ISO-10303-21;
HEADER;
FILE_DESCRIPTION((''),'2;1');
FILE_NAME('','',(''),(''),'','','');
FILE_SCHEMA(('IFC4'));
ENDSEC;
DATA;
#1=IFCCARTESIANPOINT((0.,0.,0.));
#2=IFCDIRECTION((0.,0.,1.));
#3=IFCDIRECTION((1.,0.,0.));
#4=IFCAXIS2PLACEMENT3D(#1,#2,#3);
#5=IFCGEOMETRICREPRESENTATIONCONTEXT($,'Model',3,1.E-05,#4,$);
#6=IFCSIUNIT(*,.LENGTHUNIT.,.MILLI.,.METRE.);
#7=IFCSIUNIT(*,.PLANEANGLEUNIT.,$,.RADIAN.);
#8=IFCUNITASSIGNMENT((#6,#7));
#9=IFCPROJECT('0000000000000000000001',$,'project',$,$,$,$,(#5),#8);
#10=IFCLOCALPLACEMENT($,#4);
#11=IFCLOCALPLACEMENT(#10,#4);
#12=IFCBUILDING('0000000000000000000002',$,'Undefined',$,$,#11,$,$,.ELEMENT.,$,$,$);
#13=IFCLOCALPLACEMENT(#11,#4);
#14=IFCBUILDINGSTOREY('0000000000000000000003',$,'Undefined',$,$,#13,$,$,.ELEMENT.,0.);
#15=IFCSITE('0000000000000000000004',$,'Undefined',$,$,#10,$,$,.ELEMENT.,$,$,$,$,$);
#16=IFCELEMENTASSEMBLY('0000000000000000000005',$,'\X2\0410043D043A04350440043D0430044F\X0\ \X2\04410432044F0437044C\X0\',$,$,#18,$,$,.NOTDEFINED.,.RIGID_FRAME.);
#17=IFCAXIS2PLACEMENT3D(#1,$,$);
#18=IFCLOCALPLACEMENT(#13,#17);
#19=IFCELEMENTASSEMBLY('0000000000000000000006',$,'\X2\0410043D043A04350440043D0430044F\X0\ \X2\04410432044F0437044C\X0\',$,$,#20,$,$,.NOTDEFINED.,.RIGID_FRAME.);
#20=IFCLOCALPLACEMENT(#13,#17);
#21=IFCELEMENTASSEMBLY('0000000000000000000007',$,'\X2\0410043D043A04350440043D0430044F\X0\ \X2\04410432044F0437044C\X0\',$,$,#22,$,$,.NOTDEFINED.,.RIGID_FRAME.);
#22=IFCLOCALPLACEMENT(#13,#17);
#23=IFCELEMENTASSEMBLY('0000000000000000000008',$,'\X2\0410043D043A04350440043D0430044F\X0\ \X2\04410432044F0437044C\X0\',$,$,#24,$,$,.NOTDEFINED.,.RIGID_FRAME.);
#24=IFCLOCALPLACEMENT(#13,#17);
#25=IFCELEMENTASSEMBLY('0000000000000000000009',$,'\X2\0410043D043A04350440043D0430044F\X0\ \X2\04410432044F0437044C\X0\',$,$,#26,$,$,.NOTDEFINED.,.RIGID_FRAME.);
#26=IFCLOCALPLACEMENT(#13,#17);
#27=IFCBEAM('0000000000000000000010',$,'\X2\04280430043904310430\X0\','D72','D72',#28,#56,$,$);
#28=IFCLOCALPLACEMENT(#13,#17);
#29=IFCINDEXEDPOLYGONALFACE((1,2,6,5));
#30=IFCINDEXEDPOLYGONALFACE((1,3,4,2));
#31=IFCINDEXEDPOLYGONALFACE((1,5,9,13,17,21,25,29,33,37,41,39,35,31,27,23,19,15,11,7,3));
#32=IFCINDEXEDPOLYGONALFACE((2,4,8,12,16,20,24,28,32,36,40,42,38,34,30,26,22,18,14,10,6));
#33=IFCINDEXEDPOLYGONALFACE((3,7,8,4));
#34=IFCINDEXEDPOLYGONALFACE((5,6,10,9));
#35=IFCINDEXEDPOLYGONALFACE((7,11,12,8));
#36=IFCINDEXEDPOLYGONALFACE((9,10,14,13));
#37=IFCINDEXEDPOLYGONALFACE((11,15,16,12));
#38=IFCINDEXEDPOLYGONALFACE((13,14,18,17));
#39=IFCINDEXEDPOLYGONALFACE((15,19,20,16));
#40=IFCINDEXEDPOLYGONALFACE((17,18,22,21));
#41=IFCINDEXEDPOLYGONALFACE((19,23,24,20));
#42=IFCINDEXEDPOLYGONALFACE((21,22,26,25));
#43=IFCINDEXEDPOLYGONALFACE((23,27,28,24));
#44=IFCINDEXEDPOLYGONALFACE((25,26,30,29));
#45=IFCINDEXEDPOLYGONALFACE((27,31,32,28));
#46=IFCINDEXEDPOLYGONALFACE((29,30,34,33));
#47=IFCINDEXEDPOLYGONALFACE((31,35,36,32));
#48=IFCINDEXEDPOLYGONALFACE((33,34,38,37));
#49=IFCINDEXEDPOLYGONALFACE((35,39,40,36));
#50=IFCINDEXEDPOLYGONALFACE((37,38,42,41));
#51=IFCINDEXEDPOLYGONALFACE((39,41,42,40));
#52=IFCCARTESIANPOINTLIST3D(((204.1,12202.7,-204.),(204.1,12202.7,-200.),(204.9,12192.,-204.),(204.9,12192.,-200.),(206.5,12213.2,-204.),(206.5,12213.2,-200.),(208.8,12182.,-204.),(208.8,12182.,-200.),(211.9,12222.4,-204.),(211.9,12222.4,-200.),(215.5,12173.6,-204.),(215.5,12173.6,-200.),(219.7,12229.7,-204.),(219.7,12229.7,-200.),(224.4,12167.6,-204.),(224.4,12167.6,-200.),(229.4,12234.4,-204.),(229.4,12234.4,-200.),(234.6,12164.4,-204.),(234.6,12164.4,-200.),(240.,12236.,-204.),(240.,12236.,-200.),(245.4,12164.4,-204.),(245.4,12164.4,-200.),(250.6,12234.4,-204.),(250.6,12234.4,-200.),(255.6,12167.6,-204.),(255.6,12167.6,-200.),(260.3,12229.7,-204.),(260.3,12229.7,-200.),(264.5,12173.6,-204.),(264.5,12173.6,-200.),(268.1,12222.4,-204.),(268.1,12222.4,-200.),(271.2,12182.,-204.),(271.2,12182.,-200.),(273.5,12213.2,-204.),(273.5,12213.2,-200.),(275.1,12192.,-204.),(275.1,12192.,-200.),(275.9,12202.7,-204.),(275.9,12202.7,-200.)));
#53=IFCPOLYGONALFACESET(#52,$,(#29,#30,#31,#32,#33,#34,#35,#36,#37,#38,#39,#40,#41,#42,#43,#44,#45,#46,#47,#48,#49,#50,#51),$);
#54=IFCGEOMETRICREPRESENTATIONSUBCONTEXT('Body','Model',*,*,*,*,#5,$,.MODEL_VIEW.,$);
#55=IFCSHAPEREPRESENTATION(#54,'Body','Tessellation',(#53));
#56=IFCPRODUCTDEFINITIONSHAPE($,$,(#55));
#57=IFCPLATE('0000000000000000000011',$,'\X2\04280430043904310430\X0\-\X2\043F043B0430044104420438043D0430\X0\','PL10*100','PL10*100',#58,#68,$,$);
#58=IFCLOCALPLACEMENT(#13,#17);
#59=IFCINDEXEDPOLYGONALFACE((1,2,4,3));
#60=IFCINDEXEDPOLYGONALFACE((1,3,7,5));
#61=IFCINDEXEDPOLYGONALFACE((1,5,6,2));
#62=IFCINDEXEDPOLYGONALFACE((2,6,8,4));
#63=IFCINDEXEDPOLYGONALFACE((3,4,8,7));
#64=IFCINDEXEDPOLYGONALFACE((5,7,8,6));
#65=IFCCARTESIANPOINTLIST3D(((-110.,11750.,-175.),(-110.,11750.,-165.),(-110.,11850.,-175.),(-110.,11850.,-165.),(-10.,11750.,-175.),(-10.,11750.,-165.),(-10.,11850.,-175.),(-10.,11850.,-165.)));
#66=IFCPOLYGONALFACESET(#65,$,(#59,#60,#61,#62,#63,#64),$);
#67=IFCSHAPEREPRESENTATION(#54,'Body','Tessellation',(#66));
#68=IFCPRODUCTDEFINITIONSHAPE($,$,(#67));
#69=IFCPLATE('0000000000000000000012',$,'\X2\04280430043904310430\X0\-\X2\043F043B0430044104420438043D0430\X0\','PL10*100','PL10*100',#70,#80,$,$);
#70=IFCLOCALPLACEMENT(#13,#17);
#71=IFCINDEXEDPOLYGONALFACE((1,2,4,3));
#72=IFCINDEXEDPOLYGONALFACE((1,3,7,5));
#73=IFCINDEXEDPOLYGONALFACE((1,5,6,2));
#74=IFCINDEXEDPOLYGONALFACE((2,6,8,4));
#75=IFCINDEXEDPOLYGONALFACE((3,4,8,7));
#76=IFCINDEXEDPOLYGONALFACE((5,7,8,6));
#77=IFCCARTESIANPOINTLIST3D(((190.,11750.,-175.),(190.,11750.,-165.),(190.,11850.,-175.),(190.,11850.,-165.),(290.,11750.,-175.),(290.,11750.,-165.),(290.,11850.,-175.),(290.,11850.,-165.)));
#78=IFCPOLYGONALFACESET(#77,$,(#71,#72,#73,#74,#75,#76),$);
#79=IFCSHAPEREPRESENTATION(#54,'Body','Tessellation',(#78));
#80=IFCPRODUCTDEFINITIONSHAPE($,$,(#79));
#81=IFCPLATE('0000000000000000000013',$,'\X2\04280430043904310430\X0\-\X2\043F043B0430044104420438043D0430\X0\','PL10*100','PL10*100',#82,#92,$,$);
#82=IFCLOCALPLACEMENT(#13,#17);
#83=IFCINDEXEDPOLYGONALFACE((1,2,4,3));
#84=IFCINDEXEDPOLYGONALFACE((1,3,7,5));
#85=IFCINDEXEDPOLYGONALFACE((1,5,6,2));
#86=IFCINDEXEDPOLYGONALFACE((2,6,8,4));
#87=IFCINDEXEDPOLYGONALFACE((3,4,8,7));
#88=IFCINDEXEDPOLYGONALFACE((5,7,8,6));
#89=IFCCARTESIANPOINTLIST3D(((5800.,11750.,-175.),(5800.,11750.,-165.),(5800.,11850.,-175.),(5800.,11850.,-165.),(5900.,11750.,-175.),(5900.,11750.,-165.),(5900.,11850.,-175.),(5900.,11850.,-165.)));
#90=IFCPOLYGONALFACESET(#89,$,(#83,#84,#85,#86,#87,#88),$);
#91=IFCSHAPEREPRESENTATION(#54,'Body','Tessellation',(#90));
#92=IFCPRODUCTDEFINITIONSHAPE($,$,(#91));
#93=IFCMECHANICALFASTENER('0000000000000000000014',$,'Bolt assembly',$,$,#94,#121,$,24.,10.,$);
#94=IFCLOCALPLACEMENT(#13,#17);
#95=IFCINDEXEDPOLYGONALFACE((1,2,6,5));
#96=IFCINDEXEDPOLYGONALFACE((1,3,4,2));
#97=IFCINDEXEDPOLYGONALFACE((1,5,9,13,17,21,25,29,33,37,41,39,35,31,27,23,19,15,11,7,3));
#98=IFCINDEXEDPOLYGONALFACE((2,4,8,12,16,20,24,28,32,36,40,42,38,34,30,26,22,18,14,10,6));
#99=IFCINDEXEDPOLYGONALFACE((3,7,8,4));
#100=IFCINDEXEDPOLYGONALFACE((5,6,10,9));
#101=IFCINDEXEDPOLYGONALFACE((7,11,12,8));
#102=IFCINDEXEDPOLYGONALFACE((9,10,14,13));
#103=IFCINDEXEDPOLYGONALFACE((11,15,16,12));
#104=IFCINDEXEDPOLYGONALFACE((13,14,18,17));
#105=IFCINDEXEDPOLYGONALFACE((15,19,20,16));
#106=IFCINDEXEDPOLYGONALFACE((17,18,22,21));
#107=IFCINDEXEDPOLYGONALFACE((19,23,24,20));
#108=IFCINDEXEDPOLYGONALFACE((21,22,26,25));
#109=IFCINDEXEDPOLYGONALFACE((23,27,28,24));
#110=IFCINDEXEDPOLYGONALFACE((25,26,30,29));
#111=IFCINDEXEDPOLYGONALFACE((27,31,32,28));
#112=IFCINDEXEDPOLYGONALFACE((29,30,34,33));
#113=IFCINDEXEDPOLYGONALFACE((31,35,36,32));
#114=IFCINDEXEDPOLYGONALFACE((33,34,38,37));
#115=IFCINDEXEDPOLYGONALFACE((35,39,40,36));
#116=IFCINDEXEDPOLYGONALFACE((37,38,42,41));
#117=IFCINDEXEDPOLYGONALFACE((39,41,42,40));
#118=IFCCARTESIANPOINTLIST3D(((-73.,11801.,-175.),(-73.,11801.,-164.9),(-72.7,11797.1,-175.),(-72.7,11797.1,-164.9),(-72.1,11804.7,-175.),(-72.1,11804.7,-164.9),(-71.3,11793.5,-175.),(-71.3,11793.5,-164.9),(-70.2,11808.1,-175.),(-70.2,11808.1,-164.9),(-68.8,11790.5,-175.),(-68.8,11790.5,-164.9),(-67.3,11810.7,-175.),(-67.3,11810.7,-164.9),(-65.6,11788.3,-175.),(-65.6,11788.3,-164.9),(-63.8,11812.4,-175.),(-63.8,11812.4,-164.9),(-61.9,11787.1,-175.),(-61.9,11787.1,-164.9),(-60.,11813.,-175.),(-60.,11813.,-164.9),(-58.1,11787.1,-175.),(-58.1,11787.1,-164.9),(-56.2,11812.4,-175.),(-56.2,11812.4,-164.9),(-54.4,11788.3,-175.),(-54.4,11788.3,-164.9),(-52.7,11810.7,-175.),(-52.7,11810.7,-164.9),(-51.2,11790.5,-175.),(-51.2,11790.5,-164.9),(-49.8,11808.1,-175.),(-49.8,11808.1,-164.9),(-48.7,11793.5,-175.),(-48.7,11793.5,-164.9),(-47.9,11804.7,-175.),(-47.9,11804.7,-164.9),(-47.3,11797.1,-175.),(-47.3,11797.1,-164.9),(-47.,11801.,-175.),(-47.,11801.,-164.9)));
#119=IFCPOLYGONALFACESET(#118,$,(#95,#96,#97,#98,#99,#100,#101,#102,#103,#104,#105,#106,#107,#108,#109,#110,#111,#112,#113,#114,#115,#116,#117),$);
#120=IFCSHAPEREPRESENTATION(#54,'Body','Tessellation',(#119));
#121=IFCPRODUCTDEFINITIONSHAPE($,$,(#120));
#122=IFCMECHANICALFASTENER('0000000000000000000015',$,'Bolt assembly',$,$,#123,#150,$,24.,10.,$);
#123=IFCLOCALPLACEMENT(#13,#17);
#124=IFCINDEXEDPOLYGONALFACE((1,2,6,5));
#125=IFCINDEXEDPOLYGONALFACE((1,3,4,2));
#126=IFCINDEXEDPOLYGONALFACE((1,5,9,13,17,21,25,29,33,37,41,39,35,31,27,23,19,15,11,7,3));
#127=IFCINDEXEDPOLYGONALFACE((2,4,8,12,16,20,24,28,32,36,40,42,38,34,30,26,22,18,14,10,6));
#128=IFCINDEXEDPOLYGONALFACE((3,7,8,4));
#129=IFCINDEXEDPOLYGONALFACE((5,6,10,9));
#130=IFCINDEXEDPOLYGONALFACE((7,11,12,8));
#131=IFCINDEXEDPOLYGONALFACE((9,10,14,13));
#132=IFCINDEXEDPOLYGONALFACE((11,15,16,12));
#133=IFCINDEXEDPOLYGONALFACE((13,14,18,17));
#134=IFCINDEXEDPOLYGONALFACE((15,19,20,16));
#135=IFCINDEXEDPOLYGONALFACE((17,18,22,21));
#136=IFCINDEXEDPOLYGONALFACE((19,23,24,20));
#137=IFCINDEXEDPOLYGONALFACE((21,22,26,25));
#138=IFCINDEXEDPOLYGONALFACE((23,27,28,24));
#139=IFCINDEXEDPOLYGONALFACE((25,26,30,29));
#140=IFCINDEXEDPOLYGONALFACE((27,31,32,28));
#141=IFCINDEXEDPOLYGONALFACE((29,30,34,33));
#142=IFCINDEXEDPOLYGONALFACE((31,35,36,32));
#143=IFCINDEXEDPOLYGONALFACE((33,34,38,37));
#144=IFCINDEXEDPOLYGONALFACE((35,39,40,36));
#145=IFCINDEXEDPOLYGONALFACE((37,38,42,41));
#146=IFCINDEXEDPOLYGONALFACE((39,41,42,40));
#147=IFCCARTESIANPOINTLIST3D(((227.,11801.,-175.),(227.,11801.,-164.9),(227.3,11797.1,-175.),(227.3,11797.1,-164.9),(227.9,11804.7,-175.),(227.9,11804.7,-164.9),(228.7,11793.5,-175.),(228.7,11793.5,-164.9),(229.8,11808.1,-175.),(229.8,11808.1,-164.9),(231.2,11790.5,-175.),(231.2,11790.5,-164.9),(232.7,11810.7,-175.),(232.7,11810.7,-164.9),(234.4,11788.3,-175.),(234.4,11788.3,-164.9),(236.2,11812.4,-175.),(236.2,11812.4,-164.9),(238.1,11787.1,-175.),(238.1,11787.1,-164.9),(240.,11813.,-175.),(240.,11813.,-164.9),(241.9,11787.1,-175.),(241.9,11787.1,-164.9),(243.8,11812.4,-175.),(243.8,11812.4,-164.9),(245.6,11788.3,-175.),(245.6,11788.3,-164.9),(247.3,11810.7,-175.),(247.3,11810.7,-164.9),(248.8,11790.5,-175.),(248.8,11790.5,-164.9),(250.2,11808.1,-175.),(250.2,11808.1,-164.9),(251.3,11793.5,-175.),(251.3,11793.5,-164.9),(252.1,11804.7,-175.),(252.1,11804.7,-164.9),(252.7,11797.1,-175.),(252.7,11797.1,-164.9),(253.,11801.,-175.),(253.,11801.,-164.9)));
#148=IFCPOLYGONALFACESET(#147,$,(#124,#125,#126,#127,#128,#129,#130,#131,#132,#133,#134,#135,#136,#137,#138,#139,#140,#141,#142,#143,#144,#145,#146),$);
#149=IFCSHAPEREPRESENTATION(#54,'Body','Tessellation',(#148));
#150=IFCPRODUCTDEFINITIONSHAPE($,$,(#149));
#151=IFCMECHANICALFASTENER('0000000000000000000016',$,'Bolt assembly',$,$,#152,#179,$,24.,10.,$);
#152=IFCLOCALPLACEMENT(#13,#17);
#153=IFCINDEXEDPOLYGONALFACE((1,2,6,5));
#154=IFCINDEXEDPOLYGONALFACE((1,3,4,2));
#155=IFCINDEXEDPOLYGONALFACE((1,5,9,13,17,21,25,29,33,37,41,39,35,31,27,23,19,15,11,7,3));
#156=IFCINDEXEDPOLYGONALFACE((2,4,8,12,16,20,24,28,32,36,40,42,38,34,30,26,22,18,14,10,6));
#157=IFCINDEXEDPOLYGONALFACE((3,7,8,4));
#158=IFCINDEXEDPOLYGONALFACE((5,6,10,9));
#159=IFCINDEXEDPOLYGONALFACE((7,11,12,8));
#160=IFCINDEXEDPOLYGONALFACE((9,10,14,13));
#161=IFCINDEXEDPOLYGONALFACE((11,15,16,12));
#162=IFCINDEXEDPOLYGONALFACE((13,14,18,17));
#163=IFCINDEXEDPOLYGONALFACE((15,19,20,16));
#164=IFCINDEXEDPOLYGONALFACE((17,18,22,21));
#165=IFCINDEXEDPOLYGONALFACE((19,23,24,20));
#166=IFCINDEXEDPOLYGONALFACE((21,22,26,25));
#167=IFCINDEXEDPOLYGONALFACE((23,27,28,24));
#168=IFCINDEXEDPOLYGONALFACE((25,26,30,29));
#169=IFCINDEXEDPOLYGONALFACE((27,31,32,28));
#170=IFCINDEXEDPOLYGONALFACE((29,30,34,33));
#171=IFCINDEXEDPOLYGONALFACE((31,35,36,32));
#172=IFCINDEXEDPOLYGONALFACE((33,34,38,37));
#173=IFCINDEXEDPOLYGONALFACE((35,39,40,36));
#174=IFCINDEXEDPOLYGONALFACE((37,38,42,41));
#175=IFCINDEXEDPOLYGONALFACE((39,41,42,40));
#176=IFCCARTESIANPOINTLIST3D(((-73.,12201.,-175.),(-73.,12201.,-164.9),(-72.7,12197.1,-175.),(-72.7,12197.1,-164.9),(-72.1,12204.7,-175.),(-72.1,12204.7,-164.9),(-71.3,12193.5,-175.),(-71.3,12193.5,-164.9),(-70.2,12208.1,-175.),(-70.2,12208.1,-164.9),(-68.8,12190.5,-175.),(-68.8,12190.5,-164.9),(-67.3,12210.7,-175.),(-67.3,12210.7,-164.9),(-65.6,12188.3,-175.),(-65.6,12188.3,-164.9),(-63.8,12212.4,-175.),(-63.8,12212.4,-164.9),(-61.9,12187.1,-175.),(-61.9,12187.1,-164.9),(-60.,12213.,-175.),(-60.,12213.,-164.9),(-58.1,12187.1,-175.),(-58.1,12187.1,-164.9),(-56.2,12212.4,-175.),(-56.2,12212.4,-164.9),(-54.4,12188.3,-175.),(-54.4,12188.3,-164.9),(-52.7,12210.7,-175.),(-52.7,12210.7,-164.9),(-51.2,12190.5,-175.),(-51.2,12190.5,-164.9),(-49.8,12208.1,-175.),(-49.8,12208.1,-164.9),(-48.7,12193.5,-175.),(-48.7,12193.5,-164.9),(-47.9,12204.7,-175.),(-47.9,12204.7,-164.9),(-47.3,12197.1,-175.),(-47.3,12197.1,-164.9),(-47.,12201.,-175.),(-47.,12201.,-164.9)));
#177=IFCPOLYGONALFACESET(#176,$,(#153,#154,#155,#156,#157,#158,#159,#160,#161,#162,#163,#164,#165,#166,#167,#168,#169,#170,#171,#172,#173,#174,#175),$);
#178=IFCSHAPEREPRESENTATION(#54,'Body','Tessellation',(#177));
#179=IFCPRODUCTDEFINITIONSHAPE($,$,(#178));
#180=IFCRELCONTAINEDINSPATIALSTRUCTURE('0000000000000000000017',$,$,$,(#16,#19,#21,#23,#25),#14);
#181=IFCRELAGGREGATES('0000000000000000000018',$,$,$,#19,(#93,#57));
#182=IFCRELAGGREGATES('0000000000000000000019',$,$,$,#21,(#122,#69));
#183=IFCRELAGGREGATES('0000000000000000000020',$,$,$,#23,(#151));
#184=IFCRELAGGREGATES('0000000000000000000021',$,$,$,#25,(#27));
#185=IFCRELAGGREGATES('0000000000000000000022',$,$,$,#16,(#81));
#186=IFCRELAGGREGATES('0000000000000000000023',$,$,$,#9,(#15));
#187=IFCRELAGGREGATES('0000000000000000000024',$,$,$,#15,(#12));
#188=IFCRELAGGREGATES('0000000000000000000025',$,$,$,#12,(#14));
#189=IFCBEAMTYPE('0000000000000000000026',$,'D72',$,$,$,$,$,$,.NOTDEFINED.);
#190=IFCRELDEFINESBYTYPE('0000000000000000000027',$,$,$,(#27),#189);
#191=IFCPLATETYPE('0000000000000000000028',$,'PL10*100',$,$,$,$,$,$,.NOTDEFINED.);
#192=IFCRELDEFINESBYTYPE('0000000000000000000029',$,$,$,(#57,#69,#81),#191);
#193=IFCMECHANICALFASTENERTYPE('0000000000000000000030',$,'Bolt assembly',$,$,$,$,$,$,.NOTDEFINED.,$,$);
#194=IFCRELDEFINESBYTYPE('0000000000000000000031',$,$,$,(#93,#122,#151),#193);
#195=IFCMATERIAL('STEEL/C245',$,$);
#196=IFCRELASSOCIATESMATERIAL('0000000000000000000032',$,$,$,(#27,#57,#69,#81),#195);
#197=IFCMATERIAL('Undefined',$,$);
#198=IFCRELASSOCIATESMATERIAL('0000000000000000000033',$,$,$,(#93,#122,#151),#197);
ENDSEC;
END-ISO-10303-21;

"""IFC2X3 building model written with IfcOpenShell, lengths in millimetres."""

from ifc_helpers import new_model, si_unit, frame, origin_with_axes, origin_2d_with_axis, place, context, subcontext, project, spatial, polyline, circle, outline, extrude, source, transform, mapped, material, type_object, element, aggregate, save


model = new_model("IFC2X3")

# Units and contexts
model_context = context("Model", 3, precision=1e-05, world=origin_with_axes())
body_context = subcontext(model_context, "Body", "Model", "MODEL_VIEW")
ifc_project = project(units=[si_unit("LENGTHUNIT", "METRE", prefix="MILLI"), si_unit("PLANEANGLEUNIT", "RADIAN")], contexts=[model_context])

# Site, building, storey
site_placement = place(None, origin_with_axes())
site = spatial("IfcSite", under=ifc_project, at=site_placement, Name="Undefined", CompositionType="ELEMENT")
building_placement = place(site_placement, origin_with_axes())
building = spatial("IfcBuilding", under=site, at=building_placement, Name="Undefined", CompositionType="ELEMENT")
storey_placement = place(building_placement, origin_with_axes())
storey = spatial("IfcBuildingStorey", under=building, at=storey_placement, Name="Undefined", CompositionType="ELEMENT", Elevation=0.0)

# Element assembly
assembly_1_placement = place(storey_placement, origin_with_axes())
assembly_1 = element("IfcElementAssembly", 1, at=assembly_1_placement, inside=storey, Name="Анкерная связь", AssemblyPlace="NOTDEFINED", PredefinedType="RIGID_FRAME")
ifc_material_1 = material(Name="STEEL/C245")

# Element assemblies
assembly_2_placement = place(storey_placement, origin_with_axes())
assembly_2 = element("IfcElementAssembly", 2, at=assembly_2_placement, inside=storey, Name="Анкерная связь", AssemblyPlace="NOTDEFINED", PredefinedType="RIGID_FRAME")
assembly_3_placement = place(storey_placement, origin_with_axes())
assembly_3 = element("IfcElementAssembly", 3, at=assembly_3_placement, inside=storey, Name="Анкерная связь", AssemblyPlace="NOTDEFINED", PredefinedType="RIGID_FRAME")
assembly_4_placement = place(storey_placement, origin_with_axes())
assembly_4 = element("IfcElementAssembly", 4, at=assembly_4_placement, inside=storey, Name="Анкерная связь", AssemblyPlace="NOTDEFINED", PredefinedType="RIGID_FRAME")
assembly_5_placement = place(storey_placement, origin_with_axes())
assembly_5 = element("IfcElementAssembly", 5, at=assembly_5_placement, inside=storey, Name="Анкерная связь", AssemblyPlace="NOTDEFINED", PredefinedType="RIGID_FRAME")

# Beam
beam_type_1 = type_object("IfcBeamType", Name="D72", PredefinedType="NOTDEFINED")
beam_1_placement = place(assembly_5_placement, frame((240.0, 12200.0, -200.0), z_axis=(-1.0, 0.0, 0.0), x_axis=(0.0, 0.0, -1.0)))
beam_1 = element("IfcBeam", 6, at=beam_1_placement, type_object=beam_type_1, material=ifc_material_1, Name="Шайба", Description="D72", ObjectType="D72", context=body_context, shape_type="SweptSolid", body=[
    extrude(circle(Radius=36.0, at=origin_2d_with_axis()), frame((4.0, 0.0, 0.0), z_axis=(-1.0, 0.0, 0.0), x_axis=(0.0, -1.0, 0.0)), (0.0, 0.0, 1.0), 4.0),
])

# Plates
plate_type = type_object("IfcPlateType", Name="PL10*100", PredefinedType="NOTDEFINED")
plate_1_placement = place(assembly_2_placement, frame((-10.0, 11850.0, -170.0), z_axis=(0.0, 0.0, -1.0), x_axis=(0.0, -1.0, 0.0)))
plate_1 = element("IfcPlate", 7, at=plate_1_placement, type_object=plate_type, material=ifc_material_1, Name="Шайба-пластина", Description="PL10*100", ObjectType="PL10*100", context=body_context, shape_type="SweptSolid", body=[
    extrude(outline(polyline([(0.0, 0.0), (100.0, 0.0), (100.0, 100.0), (0.0, 100.0), (0.0, 0.0)])), frame((0.0, 0.0, -5.0), z_axis=(0.0, 0.0, 1.0), x_axis=(1.0, 0.0, 0.0)), (0.0, 0.0, 1.0), 10.0),
])
plate_2_placement = place(assembly_3_placement, frame((290.0, 11850.0, -170.0), z_axis=(0.0, 0.0, -1.0), x_axis=(0.0, -1.0, 0.0)))
plate_2 = element("IfcPlate", 8, at=plate_2_placement, type_object=plate_type, material=ifc_material_1, Name="Шайба-пластина", Description="PL10*100", ObjectType="PL10*100", context=body_context, shape_type="SweptSolid", body=[
    extrude(outline(polyline([(0.0, 0.0), (100.0, 0.0), (100.0, 100.0), (0.0, 100.0), (0.0, 0.0)])), frame((0.0, 0.0, -5.0), z_axis=(0.0, 0.0, 1.0), x_axis=(1.0, 0.0, 0.0)), (0.0, 0.0, 1.0), 10.0),
])
plate_3_placement = place(assembly_1_placement, frame((5900.0, 11850.0, -170.0), z_axis=(0.0, 0.0, -1.0), x_axis=(0.0, -1.0, 0.0)))
plate_3 = element("IfcPlate", 9, at=plate_3_placement, type_object=plate_type, material=ifc_material_1, Name="Шайба-пластина", Description="PL10*100", ObjectType="PL10*100", context=body_context, shape_type="SweptSolid", body=[
    extrude(outline(polyline([(0.0, 0.0), (100.0, 0.0), (100.0, 100.0), (0.0, 100.0), (0.0, 0.0)])), frame((0.0, 0.0, -5.0), z_axis=(0.0, 0.0, 1.0), x_axis=(1.0, 0.0, 0.0)), (0.0, 0.0, 1.0), 10.0),
])

# Mechanical fasteners
ifc_material_2 = material(Name="Undefined")
mechanical_fastener_type = type_object("IfcMechanicalFastenerType", Name="Bolt assembly")
shared_shape_1 = source(origin_with_axes(), body_context, "Body", "SweptSolid", [
    extrude(circle(Radius=13.0, at=origin_2d_with_axis()), frame((0.0, 0.0, 0.0), z_axis=(0.0, 1.0, 0.0), x_axis=(1.0, 0.0, 0.0)), (0.0, 0.0, 1.0), 10.1),
])
mechanical_fastener_1_placement = place(assembly_2_placement, frame((-60.0, 11800.0, -175.0), z_axis=(1.0, 0.0, 0.0), x_axis=(0.0, 1.0, 0.0)))
mechanical_fastener_1 = element("IfcMechanicalFastener", 10, at=mechanical_fastener_1_placement, type_object=mechanical_fastener_type, material=ifc_material_2, Name="Bolt assembly", NominalDiameter=24.0, NominalLength=10.0, context=body_context, shape_type="MappedRepresentation", body=[
    mapped(shared_shape_1, transform((0.0, 0.0, 0.0))),
])
mechanical_fastener_2_placement = place(assembly_3_placement, frame((240.0, 11800.0, -175.0), z_axis=(1.0, 0.0, 0.0), x_axis=(0.0, 1.0, 0.0)))
mechanical_fastener_2 = element("IfcMechanicalFastener", 11, at=mechanical_fastener_2_placement, type_object=mechanical_fastener_type, material=ifc_material_2, Name="Bolt assembly", NominalDiameter=24.0, NominalLength=10.0, context=body_context, shape_type="MappedRepresentation", body=[
    mapped(shared_shape_1, transform((0.0, 0.0, 0.0))),
])
mechanical_fastener_3_placement = place(assembly_4_placement, frame((-60.0, 12200.0, -175.0), z_axis=(1.0, 0.0, 0.0), x_axis=(0.0, 1.0, 0.0)))
mechanical_fastener_3 = element("IfcMechanicalFastener", 12, at=mechanical_fastener_3_placement, type_object=mechanical_fastener_type, material=ifc_material_2, Name="Bolt assembly", NominalDiameter=24.0, NominalLength=10.0, context=body_context, shape_type="MappedRepresentation", body=[
    mapped(shared_shape_1, transform((0.0, 0.0, 0.0))),
])
aggregate(assembly_2, [mechanical_fastener_1, plate_1])
aggregate(assembly_3, [mechanical_fastener_2, plate_2])
aggregate(assembly_4, [mechanical_fastener_3])
aggregate(assembly_5, [beam_1])
aggregate(assembly_1, [plate_3])

save(model, "model.ifc")
